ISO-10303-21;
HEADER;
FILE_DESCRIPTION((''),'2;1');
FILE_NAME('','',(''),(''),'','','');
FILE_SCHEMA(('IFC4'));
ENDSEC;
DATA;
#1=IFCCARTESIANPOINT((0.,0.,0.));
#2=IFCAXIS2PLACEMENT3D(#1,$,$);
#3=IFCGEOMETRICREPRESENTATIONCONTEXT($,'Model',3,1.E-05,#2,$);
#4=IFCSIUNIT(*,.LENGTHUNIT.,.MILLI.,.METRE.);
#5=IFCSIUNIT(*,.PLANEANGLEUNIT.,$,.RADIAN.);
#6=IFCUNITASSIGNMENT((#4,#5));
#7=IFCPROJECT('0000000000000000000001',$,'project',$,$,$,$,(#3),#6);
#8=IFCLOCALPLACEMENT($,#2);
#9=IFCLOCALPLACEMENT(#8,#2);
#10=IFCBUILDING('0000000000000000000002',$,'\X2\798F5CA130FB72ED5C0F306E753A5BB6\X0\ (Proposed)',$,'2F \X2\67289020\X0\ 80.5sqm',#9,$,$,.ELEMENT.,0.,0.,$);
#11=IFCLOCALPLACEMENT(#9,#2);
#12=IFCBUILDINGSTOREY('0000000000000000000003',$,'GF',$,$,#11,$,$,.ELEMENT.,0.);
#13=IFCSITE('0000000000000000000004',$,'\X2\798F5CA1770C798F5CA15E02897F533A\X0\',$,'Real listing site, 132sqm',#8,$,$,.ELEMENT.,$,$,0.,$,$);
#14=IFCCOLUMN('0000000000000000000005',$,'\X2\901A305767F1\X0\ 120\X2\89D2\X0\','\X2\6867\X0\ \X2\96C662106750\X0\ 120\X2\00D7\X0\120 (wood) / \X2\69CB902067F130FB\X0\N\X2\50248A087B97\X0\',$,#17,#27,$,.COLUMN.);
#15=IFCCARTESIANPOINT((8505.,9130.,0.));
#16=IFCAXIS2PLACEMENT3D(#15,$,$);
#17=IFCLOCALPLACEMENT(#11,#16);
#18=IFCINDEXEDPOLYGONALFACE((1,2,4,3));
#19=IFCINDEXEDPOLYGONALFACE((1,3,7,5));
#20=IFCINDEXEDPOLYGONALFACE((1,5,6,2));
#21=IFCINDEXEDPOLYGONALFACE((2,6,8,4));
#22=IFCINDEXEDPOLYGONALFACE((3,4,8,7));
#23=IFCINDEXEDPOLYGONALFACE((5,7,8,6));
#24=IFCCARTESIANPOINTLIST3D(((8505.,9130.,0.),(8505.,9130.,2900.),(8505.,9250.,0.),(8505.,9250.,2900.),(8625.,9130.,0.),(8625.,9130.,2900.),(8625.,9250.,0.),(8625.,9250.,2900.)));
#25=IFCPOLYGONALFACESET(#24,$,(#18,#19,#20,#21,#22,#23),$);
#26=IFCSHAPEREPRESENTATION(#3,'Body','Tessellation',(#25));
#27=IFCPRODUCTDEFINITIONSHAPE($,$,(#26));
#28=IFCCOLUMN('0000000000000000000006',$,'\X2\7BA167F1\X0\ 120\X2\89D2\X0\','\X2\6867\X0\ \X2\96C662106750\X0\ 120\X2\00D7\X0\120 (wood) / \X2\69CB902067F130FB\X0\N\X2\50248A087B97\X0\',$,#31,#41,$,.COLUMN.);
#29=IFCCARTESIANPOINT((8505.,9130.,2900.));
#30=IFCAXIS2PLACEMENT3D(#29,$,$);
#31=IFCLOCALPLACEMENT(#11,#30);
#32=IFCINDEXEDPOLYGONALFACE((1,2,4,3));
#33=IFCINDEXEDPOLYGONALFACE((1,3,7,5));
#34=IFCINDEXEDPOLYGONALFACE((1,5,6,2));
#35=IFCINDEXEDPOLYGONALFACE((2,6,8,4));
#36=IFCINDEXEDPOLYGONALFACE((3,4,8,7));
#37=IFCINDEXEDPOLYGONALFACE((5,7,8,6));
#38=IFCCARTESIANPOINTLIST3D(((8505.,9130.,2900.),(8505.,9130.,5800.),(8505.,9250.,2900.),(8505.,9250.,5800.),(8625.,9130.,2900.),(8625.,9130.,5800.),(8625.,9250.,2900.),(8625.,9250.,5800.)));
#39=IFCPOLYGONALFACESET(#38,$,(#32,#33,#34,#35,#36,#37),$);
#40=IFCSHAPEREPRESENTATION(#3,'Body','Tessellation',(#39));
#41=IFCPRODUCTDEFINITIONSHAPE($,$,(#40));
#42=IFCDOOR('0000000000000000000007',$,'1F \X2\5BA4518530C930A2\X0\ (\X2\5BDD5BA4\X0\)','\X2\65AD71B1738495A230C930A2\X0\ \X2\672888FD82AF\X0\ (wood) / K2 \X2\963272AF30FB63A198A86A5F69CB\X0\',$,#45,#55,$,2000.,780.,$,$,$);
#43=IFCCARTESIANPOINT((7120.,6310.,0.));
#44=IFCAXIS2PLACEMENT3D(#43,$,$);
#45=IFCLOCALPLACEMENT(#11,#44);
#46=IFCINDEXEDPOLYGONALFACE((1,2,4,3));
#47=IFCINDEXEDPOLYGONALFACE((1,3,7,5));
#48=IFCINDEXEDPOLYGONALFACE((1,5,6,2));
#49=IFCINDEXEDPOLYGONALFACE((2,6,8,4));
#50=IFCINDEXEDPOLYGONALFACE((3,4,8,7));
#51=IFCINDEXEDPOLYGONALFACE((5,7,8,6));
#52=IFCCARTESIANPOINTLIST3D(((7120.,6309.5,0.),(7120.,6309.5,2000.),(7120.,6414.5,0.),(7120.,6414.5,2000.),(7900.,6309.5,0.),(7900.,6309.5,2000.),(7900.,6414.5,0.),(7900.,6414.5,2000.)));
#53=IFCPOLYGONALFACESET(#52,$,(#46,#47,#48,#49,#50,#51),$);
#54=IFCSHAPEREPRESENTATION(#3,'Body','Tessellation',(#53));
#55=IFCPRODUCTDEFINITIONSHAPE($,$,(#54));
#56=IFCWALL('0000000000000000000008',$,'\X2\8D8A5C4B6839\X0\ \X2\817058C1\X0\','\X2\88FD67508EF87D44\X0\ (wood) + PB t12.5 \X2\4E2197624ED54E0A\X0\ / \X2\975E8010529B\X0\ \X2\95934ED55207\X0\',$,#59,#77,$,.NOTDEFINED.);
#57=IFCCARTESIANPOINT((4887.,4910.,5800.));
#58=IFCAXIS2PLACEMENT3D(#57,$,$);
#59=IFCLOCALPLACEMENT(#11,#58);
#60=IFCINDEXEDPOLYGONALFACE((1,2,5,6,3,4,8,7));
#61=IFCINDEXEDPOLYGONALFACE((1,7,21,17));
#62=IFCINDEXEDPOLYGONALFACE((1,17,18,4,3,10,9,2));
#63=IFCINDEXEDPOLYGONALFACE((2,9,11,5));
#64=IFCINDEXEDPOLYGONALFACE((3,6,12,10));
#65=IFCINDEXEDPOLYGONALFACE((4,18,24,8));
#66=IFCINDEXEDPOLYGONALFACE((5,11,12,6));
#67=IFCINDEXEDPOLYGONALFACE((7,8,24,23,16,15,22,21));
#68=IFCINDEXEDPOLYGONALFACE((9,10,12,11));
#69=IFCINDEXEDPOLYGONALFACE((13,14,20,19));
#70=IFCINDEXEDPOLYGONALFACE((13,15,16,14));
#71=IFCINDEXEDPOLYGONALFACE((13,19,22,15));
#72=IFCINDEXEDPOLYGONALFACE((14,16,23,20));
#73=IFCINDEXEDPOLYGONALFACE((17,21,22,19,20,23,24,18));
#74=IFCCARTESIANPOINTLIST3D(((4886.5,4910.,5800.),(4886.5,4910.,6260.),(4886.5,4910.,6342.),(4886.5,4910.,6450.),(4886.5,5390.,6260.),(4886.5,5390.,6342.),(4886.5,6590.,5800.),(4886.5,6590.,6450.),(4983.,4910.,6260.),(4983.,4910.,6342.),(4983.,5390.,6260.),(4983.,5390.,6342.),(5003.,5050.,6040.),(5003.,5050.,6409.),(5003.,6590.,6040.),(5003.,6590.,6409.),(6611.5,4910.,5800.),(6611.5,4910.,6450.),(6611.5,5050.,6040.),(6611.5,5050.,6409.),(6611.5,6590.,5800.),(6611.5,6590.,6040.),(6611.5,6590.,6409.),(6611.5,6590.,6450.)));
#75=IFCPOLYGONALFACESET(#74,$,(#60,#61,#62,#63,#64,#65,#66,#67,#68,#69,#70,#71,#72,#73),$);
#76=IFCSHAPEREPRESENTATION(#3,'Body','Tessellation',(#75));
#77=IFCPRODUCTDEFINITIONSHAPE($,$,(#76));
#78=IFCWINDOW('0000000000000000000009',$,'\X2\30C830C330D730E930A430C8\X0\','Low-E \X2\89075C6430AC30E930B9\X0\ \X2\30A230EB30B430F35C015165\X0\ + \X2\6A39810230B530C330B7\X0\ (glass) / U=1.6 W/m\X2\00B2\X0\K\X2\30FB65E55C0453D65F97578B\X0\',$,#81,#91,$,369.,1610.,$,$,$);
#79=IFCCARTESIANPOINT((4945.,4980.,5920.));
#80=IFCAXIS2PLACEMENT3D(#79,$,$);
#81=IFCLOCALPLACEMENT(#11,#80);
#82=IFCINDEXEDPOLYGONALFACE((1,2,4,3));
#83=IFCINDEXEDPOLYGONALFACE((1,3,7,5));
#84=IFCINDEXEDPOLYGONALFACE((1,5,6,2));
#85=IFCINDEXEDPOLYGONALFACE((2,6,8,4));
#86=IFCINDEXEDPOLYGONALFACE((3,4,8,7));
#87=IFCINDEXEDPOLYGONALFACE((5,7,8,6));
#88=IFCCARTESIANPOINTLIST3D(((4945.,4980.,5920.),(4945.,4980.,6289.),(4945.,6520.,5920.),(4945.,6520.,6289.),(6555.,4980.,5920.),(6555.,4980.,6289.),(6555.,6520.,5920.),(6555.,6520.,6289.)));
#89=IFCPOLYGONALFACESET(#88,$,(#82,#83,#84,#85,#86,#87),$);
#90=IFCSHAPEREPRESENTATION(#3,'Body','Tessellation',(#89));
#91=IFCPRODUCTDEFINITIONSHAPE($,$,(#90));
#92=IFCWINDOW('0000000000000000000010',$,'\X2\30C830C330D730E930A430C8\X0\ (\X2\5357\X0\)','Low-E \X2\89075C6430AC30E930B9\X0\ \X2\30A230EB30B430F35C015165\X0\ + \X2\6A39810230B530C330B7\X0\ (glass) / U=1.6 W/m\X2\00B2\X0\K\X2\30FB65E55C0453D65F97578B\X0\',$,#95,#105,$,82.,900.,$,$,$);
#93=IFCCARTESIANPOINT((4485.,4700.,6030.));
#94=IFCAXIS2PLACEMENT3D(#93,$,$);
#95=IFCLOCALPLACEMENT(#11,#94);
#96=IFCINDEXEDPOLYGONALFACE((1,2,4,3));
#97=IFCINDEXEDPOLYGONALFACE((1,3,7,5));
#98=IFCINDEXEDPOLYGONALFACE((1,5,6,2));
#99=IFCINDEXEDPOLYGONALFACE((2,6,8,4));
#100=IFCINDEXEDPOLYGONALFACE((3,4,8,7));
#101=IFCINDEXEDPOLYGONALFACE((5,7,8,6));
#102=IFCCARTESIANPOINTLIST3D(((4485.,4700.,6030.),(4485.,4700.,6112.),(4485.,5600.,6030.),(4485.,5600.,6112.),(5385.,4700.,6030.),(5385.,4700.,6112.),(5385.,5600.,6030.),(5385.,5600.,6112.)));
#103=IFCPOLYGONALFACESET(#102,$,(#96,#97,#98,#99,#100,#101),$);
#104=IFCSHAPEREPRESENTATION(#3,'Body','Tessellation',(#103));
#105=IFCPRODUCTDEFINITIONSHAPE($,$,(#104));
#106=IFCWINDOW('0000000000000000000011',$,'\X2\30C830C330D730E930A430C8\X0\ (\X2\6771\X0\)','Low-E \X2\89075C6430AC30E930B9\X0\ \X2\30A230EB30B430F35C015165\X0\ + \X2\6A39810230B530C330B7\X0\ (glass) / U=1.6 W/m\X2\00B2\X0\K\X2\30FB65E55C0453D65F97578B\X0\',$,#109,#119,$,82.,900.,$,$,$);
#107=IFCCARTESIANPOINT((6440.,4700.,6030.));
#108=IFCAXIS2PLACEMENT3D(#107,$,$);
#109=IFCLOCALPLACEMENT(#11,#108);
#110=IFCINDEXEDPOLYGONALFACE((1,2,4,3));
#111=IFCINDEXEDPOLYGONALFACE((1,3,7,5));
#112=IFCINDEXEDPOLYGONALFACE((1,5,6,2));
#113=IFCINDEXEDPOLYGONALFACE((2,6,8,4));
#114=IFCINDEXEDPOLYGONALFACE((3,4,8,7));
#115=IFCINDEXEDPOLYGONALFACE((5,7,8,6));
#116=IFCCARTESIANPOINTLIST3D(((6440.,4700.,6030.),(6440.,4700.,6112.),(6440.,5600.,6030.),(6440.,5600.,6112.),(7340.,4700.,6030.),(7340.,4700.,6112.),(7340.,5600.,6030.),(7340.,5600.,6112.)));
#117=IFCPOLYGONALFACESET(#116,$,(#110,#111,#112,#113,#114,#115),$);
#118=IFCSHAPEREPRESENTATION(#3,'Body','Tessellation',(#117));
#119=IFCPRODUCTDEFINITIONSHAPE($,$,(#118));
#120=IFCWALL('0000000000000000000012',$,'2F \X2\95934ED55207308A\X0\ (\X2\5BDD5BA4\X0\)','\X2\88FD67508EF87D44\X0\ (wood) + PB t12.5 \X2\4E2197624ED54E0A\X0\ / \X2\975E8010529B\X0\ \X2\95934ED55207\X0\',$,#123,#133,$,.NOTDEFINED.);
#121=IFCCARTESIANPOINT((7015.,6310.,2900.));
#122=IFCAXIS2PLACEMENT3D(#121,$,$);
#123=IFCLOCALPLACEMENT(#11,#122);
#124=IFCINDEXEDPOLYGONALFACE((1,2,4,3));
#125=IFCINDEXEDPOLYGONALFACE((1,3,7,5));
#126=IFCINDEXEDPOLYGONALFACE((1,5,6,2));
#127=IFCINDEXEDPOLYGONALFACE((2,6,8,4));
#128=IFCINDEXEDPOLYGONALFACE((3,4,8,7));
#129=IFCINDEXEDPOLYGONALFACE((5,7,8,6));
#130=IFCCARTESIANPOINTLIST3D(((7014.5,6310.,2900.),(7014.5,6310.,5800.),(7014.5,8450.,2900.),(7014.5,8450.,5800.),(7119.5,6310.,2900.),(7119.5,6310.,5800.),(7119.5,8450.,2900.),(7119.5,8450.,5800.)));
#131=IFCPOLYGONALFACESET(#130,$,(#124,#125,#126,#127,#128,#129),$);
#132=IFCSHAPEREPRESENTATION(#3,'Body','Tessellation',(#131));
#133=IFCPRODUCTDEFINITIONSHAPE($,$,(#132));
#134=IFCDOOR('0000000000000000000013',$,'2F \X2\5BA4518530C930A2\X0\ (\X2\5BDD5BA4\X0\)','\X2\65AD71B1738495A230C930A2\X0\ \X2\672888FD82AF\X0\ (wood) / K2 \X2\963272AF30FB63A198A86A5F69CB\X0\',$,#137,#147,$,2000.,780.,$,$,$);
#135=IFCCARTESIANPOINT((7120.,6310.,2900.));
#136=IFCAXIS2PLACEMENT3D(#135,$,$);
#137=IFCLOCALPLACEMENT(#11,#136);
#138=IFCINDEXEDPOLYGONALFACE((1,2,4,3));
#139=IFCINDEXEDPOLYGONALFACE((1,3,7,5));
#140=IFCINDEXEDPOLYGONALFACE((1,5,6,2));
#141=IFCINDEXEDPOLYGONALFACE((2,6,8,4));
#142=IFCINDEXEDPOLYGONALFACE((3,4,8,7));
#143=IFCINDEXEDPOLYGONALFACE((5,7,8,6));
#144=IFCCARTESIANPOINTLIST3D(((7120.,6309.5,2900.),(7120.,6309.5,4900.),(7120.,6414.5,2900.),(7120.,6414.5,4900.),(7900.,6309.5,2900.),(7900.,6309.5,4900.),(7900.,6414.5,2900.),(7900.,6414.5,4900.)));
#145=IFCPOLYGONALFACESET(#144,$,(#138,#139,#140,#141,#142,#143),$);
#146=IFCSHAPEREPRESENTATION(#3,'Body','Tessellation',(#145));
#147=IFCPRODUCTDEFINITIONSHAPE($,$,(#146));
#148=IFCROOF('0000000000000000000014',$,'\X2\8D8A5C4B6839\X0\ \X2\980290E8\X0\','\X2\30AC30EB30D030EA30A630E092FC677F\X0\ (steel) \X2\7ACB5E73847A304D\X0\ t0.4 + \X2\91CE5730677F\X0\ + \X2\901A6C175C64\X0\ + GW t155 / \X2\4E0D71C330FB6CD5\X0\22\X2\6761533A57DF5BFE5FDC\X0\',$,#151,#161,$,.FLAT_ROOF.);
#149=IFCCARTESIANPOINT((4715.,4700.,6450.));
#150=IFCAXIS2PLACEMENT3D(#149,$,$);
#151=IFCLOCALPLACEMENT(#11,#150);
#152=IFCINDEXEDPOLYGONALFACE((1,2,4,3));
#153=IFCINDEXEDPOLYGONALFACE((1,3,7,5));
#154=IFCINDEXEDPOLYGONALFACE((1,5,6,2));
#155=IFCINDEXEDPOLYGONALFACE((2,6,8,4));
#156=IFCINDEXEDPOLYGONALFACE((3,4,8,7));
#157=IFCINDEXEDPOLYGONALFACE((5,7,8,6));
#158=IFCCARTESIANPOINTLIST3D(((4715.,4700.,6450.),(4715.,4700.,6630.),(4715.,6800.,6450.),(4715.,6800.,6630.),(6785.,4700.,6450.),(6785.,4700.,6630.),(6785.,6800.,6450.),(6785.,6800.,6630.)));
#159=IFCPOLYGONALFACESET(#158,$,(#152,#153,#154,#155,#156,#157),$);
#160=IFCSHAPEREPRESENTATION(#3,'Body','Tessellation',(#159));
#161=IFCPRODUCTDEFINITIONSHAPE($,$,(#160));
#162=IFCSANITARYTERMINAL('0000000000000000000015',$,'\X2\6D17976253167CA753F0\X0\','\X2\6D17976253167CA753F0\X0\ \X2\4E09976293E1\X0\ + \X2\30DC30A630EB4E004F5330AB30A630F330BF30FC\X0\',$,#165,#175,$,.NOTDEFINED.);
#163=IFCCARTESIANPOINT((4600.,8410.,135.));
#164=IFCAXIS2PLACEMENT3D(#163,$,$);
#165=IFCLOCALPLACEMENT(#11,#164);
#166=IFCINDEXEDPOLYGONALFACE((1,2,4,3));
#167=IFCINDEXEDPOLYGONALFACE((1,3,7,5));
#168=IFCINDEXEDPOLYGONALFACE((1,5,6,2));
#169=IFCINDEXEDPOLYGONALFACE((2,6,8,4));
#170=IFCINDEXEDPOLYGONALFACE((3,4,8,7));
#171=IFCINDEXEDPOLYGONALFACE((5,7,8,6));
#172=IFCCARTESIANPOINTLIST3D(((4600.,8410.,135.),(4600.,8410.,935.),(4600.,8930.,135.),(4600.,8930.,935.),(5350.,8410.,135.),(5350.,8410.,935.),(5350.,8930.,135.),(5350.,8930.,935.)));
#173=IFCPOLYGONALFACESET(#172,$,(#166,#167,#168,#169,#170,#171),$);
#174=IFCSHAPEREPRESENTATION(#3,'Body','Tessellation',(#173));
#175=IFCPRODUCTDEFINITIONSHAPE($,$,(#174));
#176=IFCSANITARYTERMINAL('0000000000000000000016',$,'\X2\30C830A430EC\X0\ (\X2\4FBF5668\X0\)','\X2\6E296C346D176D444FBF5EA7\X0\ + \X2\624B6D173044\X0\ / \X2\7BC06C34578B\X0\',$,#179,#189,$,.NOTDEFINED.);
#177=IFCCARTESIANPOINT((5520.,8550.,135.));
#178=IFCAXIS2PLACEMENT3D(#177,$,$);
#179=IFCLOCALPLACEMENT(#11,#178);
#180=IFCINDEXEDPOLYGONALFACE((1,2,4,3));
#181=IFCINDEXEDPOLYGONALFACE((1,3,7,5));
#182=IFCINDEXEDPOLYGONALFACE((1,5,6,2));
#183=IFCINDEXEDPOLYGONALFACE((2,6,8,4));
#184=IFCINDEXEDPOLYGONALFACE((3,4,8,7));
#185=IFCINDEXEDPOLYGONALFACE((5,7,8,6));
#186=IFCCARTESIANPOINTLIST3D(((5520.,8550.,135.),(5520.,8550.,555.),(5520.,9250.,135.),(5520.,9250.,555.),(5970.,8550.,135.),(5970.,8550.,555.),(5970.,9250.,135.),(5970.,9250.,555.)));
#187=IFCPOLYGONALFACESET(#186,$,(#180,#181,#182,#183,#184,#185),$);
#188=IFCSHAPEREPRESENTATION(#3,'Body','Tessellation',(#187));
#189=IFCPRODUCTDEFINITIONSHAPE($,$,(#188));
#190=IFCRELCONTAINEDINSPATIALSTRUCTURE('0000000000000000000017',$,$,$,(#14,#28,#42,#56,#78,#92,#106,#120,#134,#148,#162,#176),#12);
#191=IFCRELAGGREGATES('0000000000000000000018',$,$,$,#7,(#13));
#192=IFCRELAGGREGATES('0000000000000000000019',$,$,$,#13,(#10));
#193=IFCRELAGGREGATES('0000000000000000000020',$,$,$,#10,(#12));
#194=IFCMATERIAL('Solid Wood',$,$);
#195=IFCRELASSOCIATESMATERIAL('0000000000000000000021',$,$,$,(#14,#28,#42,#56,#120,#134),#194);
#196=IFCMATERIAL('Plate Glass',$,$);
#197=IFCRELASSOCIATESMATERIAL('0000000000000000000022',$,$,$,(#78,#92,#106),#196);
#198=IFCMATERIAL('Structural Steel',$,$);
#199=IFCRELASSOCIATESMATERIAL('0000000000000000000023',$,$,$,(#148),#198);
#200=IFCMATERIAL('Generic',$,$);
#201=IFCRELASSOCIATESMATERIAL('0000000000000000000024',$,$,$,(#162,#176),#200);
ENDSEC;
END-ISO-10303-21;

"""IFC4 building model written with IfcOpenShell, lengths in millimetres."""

from ifc_helpers import new_model, si_unit, frame, frame_2d, origin, place, context, project, spatial, rectangle, extrude, material, element, fill, save


model = new_model("IFC4")

# Units and contexts
model_context = context("Model", 3, precision=1e-05, world=origin())
ifc_project = project(units=[si_unit("LENGTHUNIT", "METRE", prefix="MILLI"), si_unit("PLANEANGLEUNIT", "RADIAN")], contexts=[model_context])

# Site, building, storey
site_placement = place(None, origin())
site = spatial("IfcSite", under=ifc_project, at=site_placement, Name="福岡県福岡市西区", ObjectType="Real listing site, 132sqm", CompositionType="ELEMENT", RefElevation=0.0)
building_placement = place(site_placement, origin())
building = spatial("IfcBuilding", under=site, at=building_placement, Name="福岡・狭小の町家 (Proposed)", ObjectType="2F 木造 80.5sqm", CompositionType="ELEMENT", ElevationOfRefHeight=0.0, ElevationOfTerrain=0.0)
storey_placement = place(building_placement, origin())
storey = spatial("IfcBuildingStorey", under=building, at=storey_placement, Name="GF", CompositionType="ELEMENT", Elevation=0.0)

# Columns
ifc_material_1 = material(Name="Solid Wood")
column_1_placement = place(storey_placement, frame((8505.0, 9130.0, 0.0)))
element("IfcColumn", 1, at=column_1_placement, inside=storey, material=ifc_material_1, Name="通し柱 120角", Description="桧 集成材 120×120 (wood) / 構造柱・N値計算", PredefinedType="COLUMN", context=model_context, shape_type="SweptSolid", body=[
    extrude(rectangle(XDim=120.0, YDim=120.0, at=frame_2d((60.0, 60.0))), frame((8505.0, 9130.0, 0.0)), (0.0, 0.0, 1.0), 2900.0),
])
column_2_placement = place(storey_placement, frame((8505.0, 9130.0, 2900.0)))
element("IfcColumn", 2, at=column_2_placement, inside=storey, material=ifc_material_1, Name="管柱 120角", Description="桧 集成材 120×120 (wood) / 構造柱・N値計算", PredefinedType="COLUMN", context=model_context, shape_type="SweptSolid", body=[
    extrude(rectangle(XDim=120.0, YDim=120.0, at=frame_2d((60.0, 60.0))), frame((8505.0, 9130.0, 2900.0)), (0.0, 0.0, 1.0), 2900.0),
])

# Door
door_1_placement = place(storey_placement, frame((7120.0, 6310.0, 0.0)))
element("IfcDoor", 3, at=door_1_placement, inside=storey, material=ifc_material_1, Name="1F 室内ドア (寝室)", Description="断熱玄関ドア 木製芯 (wood) / K2 防犯・採風機構", OverallHeight=2000.0, OverallWidth=780.0, context=model_context, shape_type="SweptSolid", body=[
    extrude(rectangle(XDim=780.0, YDim=105.0, at=frame_2d((390.0, 52.0))), frame((7120.0, 6310.0, 0.0)), (0.0, 0.0, 1.0), 2000.0),
])

# Wall, openings, windows
wall_1_placement = place(storey_placement, frame((4887.0, 4910.0, 5800.0)))
wall_1 = element("IfcWall", 4, at=wall_1_placement, inside=storey, material=ifc_material_1, Name="越屋根 腰壁", Description="製材軸組 (wood) + PB t12.5 両面仕上 / 非耐力 間仕切", PredefinedType="NOTDEFINED", context=model_context, shape_type="SweptSolid", body=[
    extrude(rectangle(XDim=1725.0, YDim=1680.0, at=frame_2d((862.0, 840.0))), frame((4887.0, 4910.0, 5800.0)), (0.0, 0.0, 1.0), 650.0),
])
opening_1_placement = place(storey_placement, frame((4945.0, 4980.0, 5920.0)))
opening_1 = element("IfcOpeningElement", 5, at=opening_1_placement, cuts=wall_1, PredefinedType="NOTDEFINED", context=model_context, shape_type="SweptSolid", body=[
    extrude(rectangle(XDim=1610.0, YDim=1540.0, at=frame_2d((805.0, 770.0))), frame((4945.0, 4980.0, 5920.0)), (0.0, 0.0, 1.0), 369.0),
])
opening_2_placement = place(storey_placement, frame((4485.0, 4700.0, 6030.0)))
opening_2 = element("IfcOpeningElement", 6, at=opening_2_placement, cuts=wall_1, PredefinedType="NOTDEFINED", context=model_context, shape_type="SweptSolid", body=[
    extrude(rectangle(XDim=900.0, YDim=900.0, at=frame_2d((450.0, 450.0))), frame((4485.0, 4700.0, 6030.0)), (0.0, 0.0, 1.0), 82.0),
])
opening_3_placement = place(storey_placement, frame((6440.0, 4700.0, 6030.0)))
opening_3 = element("IfcOpeningElement", 7, at=opening_3_placement, cuts=wall_1, PredefinedType="NOTDEFINED", context=model_context, shape_type="SweptSolid", body=[
    extrude(rectangle(XDim=900.0, YDim=900.0, at=frame_2d((450.0, 450.0))), frame((6440.0, 4700.0, 6030.0)), (0.0, 0.0, 1.0), 82.0),
])
ifc_material_2 = material(Name="Plate Glass")
window_1_placement = place(storey_placement, frame((4945.0, 4980.0, 5920.0)))
window_1 = element("IfcWindow", 8, at=window_1_placement, inside=storey, material=ifc_material_2, Name="トップライト", Description="Low-E 複層ガラス アルゴン封入 + 樹脂サッシ (glass) / U=1.6 W/m²K・日射取得型", OverallHeight=369.0, OverallWidth=1610.0, context=model_context, shape_type="SweptSolid", body=[
    extrude(rectangle(XDim=1610.0, YDim=1540.0, at=frame_2d((805.0, 770.0))), frame((4945.0, 4980.0, 5920.0)), (0.0, 0.0, 1.0), 369.0),
])
fill(opening_1, window_1)
window_2_placement = place(storey_placement, frame((4485.0, 4700.0, 6030.0)))
window_2 = element("IfcWindow", 9, at=window_2_placement, inside=storey, material=ifc_material_2, Name="トップライト (南)", Description="Low-E 複層ガラス アルゴン封入 + 樹脂サッシ (glass) / U=1.6 W/m²K・日射取得型", OverallHeight=82.0, OverallWidth=900.0, context=model_context, shape_type="SweptSolid", body=[
    extrude(rectangle(XDim=900.0, YDim=900.0, at=frame_2d((450.0, 450.0))), frame((4485.0, 4700.0, 6030.0)), (0.0, 0.0, 1.0), 82.0),
])
fill(opening_2, window_2)
window_3_placement = place(storey_placement, frame((6440.0, 4700.0, 6030.0)))
window_3 = element("IfcWindow", 10, at=window_3_placement, inside=storey, material=ifc_material_2, Name="トップライト (東)", Description="Low-E 複層ガラス アルゴン封入 + 樹脂サッシ (glass) / U=1.6 W/m²K・日射取得型", OverallHeight=82.0, OverallWidth=900.0, context=model_context, shape_type="SweptSolid", body=[
    extrude(rectangle(XDim=900.0, YDim=900.0, at=frame_2d((450.0, 450.0))), frame((6440.0, 4700.0, 6030.0)), (0.0, 0.0, 1.0), 82.0),
])
fill(opening_3, window_3)

# Wall
wall_2_placement = place(storey_placement, frame((7015.0, 6310.0, 2900.0)))
element("IfcWall", 11, at=wall_2_placement, inside=storey, material=ifc_material_1, Name="2F 間仕切り (寝室)", Description="製材軸組 (wood) + PB t12.5 両面仕上 / 非耐力 間仕切", PredefinedType="NOTDEFINED", context=model_context, shape_type="SweptSolid", body=[
    extrude(rectangle(XDim=105.0, YDim=2140.0, at=frame_2d((52.0, 1070.0))), frame((7015.0, 6310.0, 2900.0)), (0.0, 0.0, 1.0), 2900.0),
])

# Door
door_2_placement = place(storey_placement, frame((7120.0, 6310.0, 2900.0)))
element("IfcDoor", 12, at=door_2_placement, inside=storey, material=ifc_material_1, Name="2F 室内ドア (寝室)", Description="断熱玄関ドア 木製芯 (wood) / K2 防犯・採風機構", OverallHeight=2000.0, OverallWidth=780.0, context=model_context, shape_type="SweptSolid", body=[
    extrude(rectangle(XDim=780.0, YDim=105.0, at=frame_2d((390.0, 52.0))), frame((7120.0, 6310.0, 2900.0)), (0.0, 0.0, 1.0), 2000.0),
])

# Roof
ifc_material_3 = material(Name="Structural Steel")
roof_placement = place(storey_placement, frame((4715.0, 4700.0, 6450.0)))
element("IfcRoof", 13, at=roof_placement, inside=storey, material=ifc_material_3, Name="越屋根 頂部", Description="ガルバリウム鋼板 (steel) 立平葺き t0.4 + 野地板 + 通気層 + GW t155 / 不燃・法22条区域対応", PredefinedType="FLAT_ROOF", context=model_context, shape_type="SweptSolid", body=[
    extrude(rectangle(XDim=2070.0, YDim=2100.0, at=frame_2d((1035.0, 1050.0))), frame((4715.0, 4700.0, 6450.0)), (0.0, 0.0, 1.0), 180.0),
])

# Sanitary terminals
ifc_material_4 = material(Name="Generic")
sanitary_terminal_1_placement = place(storey_placement, frame((4600.0, 8410.0, 135.0)))
element("IfcSanitaryTerminal", 14, at=sanitary_terminal_1_placement, inside=storey, material=ifc_material_4, Name="洗面化粧台", Description="洗面化粧台 三面鏡 + ボウル一体カウンター", PredefinedType="NOTDEFINED", context=model_context, shape_type="SweptSolid", body=[
    extrude(rectangle(XDim=750.0, YDim=520.0, at=frame_2d((375.0, 260.0))), frame((4600.0, 8410.0, 135.0)), (0.0, 0.0, 1.0), 800.0),
])
sanitary_terminal_2_placement = place(storey_placement, frame((5520.0, 8550.0, 135.0)))
element("IfcSanitaryTerminal", 15, at=sanitary_terminal_2_placement, inside=storey, material=ifc_material_4, Name="トイレ (便器)", Description="温水洗浄便座 + 手洗い / 節水型", PredefinedType="NOTDEFINED", context=model_context, shape_type="SweptSolid", body=[
    extrude(rectangle(XDim=450.0, YDim=700.0, at=frame_2d((225.0, 350.0))), frame((5520.0, 8550.0, 135.0)), (0.0, 0.0, 1.0), 420.0),
])

save(model, "model.ifc")
